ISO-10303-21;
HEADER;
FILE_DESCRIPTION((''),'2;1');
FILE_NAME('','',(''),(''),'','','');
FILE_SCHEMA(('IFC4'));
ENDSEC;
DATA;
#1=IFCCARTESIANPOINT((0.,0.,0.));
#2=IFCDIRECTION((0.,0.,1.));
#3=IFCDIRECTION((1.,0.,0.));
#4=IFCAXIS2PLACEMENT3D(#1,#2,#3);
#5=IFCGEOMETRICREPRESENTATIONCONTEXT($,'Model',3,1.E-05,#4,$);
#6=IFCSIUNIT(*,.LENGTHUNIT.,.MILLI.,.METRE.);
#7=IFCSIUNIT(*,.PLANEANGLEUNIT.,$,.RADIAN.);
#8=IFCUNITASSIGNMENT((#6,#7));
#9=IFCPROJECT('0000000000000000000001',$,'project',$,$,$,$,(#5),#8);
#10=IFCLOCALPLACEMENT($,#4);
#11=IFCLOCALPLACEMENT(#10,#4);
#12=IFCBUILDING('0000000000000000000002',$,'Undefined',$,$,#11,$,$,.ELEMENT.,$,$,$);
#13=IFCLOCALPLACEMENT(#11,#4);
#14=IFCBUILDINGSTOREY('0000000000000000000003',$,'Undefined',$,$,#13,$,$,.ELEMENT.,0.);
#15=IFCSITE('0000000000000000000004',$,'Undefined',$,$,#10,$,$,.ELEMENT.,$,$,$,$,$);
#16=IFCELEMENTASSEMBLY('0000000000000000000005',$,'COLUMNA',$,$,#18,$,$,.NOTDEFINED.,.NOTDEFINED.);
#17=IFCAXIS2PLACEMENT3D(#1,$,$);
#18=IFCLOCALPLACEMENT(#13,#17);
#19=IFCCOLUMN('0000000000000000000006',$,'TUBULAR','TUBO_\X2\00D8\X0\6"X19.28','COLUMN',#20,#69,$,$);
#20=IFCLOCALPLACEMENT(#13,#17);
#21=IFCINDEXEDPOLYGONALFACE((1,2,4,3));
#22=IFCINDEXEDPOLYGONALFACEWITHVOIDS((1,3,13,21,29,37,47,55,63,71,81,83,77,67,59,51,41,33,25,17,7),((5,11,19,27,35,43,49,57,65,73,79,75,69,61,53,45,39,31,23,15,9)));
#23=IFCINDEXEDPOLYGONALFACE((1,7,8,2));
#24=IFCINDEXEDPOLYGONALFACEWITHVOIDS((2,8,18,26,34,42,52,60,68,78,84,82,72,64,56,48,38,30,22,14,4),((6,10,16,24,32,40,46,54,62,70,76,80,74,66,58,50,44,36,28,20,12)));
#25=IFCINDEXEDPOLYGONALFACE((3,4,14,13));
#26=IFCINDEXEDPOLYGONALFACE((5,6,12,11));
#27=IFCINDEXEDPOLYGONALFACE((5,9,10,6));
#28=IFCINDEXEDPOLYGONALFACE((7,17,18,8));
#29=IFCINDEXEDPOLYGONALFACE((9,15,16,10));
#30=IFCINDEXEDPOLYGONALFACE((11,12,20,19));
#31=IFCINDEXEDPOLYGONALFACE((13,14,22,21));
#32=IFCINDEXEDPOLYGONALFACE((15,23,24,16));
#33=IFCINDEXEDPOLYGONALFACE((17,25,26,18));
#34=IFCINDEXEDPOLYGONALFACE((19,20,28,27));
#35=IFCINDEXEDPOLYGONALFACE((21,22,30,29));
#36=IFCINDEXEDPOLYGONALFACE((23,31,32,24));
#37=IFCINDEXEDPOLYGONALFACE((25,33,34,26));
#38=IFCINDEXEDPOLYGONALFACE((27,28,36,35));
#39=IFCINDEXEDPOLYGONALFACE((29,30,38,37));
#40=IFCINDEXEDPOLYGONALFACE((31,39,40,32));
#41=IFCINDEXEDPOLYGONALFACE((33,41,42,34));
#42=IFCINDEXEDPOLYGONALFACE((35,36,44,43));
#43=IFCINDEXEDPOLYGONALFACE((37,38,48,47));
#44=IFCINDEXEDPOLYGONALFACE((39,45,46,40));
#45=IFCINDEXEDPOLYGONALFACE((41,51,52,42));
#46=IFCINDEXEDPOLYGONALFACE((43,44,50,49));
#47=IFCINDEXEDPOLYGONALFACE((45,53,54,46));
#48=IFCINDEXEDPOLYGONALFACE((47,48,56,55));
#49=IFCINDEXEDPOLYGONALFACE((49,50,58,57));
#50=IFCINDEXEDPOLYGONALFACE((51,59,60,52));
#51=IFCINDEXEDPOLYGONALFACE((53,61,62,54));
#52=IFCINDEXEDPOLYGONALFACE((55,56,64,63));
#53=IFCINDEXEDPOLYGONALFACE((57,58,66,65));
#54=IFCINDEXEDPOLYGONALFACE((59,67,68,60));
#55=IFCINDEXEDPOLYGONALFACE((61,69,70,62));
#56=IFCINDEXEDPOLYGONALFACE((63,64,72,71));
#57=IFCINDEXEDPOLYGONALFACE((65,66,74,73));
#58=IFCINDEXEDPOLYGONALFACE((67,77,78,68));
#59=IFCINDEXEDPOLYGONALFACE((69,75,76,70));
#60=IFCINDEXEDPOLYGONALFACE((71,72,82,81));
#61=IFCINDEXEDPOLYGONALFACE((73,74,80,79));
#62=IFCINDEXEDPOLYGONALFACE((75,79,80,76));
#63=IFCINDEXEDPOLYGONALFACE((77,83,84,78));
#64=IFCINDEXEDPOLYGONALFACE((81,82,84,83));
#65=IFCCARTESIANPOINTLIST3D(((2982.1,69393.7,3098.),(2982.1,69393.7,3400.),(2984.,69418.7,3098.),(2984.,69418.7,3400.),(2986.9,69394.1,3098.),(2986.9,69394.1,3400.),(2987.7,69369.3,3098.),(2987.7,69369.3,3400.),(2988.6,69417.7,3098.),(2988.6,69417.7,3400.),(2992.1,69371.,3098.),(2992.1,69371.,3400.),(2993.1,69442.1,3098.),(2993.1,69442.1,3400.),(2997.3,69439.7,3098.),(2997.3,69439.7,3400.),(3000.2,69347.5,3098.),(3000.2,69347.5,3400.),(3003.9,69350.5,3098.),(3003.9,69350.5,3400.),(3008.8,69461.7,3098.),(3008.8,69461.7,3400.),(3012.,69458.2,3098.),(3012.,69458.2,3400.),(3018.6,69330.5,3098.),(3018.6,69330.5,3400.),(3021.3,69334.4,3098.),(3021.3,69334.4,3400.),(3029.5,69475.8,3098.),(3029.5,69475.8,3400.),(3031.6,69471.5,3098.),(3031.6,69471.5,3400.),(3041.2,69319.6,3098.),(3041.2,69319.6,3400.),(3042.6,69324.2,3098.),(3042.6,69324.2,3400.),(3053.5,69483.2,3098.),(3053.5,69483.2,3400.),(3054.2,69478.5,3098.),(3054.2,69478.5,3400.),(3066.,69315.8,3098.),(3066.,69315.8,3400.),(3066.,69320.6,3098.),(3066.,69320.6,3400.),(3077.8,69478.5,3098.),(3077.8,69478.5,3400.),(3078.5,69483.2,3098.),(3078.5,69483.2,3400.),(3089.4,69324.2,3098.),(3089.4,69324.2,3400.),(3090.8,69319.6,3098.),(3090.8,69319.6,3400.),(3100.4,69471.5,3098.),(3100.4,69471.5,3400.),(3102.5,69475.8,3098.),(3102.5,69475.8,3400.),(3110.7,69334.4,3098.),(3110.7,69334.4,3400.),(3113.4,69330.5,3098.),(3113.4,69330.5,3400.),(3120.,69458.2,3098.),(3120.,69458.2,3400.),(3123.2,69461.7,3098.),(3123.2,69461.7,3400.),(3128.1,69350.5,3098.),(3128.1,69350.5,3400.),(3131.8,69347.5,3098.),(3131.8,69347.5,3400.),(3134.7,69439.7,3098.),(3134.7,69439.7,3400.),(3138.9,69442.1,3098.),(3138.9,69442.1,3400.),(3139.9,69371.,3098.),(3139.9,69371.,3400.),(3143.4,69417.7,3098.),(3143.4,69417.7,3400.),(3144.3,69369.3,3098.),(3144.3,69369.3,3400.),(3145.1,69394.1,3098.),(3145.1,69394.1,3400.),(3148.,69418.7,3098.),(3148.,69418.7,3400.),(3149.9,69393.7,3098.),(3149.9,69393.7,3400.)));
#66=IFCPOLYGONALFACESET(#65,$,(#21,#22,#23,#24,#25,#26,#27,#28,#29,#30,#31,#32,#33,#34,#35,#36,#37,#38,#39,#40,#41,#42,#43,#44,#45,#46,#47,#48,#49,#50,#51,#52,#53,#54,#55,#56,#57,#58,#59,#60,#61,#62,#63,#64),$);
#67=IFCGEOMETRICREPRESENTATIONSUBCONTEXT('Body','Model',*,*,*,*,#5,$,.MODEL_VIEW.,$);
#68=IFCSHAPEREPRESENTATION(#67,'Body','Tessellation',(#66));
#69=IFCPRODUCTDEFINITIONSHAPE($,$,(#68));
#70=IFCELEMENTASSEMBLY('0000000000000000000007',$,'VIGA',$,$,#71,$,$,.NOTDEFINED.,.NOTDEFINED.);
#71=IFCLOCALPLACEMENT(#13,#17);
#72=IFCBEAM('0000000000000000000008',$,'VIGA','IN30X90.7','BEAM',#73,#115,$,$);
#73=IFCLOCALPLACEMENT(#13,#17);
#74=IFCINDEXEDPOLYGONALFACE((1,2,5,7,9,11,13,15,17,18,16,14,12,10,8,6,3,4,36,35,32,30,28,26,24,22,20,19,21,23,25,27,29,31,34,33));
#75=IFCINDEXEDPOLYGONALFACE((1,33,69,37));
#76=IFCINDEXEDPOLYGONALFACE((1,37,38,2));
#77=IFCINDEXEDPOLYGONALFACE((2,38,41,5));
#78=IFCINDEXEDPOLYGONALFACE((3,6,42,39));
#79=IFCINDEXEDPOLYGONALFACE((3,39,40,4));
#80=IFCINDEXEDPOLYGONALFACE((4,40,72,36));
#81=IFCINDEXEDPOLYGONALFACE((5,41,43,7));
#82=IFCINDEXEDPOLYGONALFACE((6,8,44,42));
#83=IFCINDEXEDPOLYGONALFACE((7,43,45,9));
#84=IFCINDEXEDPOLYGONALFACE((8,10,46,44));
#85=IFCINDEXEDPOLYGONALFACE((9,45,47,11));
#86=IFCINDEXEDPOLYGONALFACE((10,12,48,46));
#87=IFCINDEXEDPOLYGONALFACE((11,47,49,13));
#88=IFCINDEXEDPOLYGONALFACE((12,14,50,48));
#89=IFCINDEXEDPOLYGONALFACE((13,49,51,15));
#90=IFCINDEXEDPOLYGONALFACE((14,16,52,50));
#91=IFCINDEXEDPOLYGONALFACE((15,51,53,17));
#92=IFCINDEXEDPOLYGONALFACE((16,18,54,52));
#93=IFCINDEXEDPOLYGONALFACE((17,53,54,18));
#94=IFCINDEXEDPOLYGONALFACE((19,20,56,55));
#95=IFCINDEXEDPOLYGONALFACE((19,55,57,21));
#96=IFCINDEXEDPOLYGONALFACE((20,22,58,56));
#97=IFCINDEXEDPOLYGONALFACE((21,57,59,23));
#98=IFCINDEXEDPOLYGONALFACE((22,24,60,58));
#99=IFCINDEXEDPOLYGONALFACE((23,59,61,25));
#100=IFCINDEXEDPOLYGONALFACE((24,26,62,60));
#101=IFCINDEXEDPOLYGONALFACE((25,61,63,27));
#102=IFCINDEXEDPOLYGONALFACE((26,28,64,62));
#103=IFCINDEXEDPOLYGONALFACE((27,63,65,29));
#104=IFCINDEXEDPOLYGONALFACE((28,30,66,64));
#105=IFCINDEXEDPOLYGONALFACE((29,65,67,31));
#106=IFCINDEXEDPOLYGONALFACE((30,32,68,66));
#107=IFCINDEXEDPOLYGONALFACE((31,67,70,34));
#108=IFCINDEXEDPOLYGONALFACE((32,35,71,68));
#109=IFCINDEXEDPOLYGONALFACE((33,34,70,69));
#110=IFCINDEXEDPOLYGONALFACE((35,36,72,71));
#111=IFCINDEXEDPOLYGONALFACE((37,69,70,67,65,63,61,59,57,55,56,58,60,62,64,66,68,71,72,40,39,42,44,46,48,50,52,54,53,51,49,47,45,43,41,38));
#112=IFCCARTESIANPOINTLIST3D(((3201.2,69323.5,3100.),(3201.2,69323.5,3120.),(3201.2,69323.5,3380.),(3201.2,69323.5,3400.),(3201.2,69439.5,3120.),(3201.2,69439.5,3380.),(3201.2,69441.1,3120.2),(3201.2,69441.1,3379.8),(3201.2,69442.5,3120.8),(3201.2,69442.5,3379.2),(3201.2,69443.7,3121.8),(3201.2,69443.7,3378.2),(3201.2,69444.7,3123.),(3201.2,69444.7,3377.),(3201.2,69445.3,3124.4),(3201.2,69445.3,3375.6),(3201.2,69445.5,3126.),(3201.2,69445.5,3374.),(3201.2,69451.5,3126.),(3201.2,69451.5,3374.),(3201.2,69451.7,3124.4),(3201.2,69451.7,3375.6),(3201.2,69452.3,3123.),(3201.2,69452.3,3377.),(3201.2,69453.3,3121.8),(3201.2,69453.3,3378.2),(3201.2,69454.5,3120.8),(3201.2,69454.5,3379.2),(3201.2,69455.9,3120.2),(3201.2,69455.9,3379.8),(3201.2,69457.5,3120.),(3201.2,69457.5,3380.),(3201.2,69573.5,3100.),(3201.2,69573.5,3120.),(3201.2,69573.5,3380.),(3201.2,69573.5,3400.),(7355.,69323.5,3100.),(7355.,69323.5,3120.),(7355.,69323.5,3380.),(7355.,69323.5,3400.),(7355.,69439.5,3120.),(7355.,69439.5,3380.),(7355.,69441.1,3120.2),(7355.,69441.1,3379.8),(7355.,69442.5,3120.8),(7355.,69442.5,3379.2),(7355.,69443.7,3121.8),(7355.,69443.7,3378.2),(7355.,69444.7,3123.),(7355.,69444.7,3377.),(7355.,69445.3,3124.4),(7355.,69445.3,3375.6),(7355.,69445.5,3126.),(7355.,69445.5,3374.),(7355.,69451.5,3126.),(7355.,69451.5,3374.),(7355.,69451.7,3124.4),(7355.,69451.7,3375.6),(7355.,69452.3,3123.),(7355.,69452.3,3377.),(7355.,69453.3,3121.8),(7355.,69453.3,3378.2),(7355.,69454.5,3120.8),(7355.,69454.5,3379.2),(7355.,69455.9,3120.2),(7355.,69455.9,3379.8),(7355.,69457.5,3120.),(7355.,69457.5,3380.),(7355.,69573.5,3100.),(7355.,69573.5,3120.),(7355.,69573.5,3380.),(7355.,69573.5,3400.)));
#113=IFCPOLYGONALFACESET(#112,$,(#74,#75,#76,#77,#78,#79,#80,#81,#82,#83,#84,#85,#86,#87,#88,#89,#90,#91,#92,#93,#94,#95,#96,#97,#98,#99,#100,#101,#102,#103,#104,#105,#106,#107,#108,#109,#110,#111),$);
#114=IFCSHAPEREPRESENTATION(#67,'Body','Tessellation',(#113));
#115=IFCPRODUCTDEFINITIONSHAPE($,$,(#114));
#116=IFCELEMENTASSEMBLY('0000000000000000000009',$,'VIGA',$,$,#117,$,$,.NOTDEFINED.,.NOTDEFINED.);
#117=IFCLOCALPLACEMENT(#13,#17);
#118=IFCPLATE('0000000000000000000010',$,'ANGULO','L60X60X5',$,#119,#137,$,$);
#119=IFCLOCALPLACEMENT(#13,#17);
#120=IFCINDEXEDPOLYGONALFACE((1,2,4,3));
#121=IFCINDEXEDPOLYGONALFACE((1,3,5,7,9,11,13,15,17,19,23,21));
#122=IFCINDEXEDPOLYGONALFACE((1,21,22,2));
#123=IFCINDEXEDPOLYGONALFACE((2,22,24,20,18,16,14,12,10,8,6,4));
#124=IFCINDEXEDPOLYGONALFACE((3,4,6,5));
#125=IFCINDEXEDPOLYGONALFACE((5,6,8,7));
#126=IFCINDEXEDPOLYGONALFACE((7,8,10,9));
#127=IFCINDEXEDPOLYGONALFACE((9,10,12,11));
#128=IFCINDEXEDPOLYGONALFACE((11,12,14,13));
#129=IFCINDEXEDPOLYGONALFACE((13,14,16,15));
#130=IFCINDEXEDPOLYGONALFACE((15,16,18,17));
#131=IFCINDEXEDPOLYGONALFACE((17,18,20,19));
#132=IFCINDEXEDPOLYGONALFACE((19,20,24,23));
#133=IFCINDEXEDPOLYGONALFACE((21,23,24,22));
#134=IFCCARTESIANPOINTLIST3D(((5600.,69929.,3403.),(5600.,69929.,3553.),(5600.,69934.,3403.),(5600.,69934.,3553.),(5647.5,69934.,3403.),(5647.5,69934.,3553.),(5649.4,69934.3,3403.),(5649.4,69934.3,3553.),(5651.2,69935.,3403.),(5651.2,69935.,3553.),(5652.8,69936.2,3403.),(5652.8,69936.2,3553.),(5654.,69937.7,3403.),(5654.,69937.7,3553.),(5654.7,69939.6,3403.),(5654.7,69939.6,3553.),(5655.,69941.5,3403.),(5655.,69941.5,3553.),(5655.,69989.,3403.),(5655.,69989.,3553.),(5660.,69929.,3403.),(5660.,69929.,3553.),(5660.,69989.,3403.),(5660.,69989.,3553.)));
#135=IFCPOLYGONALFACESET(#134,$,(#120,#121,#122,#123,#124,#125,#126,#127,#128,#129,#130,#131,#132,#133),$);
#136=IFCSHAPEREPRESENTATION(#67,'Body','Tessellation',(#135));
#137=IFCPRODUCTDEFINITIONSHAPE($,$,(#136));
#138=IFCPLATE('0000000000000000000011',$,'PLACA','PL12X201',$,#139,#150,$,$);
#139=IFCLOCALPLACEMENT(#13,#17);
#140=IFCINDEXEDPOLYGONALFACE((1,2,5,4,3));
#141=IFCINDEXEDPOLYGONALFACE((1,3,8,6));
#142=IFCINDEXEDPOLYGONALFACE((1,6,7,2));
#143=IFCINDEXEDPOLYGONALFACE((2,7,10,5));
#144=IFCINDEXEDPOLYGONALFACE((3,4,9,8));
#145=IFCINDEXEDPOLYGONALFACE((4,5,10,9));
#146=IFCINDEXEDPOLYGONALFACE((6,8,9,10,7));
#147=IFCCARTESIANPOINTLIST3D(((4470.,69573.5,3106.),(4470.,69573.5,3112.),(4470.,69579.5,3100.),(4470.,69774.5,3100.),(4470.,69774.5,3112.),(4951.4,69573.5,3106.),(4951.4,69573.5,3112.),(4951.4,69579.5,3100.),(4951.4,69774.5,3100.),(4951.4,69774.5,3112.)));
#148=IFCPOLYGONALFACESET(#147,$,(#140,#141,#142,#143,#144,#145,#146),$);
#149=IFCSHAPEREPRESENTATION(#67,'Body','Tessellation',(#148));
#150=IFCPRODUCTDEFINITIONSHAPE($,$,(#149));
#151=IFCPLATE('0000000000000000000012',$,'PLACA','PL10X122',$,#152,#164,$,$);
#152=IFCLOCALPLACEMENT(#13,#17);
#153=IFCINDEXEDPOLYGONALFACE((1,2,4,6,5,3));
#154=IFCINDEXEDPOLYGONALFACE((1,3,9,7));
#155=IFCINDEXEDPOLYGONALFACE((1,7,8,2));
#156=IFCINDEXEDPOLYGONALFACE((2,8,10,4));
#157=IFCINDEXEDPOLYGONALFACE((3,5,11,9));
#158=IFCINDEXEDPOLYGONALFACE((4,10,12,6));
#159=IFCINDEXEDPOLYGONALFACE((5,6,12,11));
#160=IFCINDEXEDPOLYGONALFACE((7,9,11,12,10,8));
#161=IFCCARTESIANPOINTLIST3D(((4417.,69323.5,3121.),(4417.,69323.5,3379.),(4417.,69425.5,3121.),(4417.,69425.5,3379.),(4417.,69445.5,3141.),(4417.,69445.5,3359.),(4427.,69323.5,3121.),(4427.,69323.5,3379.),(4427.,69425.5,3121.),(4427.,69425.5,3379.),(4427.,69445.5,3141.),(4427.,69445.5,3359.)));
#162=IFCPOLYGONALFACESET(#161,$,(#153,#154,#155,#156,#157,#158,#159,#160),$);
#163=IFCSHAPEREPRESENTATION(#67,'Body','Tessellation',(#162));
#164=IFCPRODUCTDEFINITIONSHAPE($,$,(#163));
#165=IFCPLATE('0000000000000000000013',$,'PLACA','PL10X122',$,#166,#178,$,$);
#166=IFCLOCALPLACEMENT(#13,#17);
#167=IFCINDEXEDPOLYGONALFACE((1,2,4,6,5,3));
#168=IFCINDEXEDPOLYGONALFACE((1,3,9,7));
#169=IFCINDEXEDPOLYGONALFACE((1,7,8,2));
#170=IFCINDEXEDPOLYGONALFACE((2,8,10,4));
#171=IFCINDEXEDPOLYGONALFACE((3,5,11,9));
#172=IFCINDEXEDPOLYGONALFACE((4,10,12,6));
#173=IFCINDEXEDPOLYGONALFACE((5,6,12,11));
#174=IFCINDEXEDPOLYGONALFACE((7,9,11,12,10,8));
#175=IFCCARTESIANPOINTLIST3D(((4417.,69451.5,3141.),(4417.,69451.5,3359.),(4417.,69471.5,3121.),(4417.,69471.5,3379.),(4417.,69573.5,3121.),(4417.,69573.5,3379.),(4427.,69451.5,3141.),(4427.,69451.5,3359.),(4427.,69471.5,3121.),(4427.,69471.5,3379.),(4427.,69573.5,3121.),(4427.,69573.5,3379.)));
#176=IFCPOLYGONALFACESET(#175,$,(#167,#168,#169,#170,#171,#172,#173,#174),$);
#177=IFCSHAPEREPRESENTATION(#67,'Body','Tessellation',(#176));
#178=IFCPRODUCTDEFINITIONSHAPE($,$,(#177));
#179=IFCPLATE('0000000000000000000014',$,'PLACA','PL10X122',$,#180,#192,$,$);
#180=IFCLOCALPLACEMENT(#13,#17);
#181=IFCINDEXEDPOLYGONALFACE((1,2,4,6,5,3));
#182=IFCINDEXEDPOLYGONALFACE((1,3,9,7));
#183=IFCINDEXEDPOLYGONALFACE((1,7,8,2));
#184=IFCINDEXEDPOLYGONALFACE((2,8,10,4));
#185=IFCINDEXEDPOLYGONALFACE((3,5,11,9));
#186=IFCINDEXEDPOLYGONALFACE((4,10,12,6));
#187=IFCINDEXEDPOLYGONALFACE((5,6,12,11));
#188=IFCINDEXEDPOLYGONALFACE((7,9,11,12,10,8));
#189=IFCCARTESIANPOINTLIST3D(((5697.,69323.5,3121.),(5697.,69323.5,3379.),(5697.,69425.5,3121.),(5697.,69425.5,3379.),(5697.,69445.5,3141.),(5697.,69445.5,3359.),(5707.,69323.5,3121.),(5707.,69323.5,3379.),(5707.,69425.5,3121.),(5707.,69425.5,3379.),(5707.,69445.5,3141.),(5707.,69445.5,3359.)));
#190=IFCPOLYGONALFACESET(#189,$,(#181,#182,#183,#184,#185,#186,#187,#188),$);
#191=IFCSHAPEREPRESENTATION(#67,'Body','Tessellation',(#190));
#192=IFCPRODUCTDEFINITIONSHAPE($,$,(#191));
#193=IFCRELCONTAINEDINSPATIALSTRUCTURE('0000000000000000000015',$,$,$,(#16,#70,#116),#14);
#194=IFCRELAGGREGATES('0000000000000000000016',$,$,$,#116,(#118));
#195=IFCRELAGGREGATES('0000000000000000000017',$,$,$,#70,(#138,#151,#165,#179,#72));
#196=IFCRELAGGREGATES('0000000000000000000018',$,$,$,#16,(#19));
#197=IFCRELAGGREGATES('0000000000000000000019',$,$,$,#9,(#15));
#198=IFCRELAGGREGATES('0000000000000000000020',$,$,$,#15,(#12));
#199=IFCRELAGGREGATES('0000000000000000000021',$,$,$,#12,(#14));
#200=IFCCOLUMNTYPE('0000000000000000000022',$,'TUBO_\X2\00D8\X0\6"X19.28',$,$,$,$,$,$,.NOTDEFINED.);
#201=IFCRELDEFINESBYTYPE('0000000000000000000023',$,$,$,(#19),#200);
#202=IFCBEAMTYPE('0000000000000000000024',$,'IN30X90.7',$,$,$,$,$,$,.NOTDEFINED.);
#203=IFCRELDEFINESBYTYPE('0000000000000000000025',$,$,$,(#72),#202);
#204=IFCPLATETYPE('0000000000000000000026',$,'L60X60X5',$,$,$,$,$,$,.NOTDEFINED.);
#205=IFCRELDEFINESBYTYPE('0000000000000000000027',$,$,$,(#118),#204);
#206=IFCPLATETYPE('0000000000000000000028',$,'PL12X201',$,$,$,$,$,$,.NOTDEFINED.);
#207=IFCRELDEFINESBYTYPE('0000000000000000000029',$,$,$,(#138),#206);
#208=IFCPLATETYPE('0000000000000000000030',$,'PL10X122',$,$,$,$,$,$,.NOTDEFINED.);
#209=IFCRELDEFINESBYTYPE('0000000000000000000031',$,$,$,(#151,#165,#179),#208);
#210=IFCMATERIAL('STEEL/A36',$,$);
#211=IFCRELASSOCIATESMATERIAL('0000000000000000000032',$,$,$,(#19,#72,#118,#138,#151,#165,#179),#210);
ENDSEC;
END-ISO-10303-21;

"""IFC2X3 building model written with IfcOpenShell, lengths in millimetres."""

from ifc_helpers import new_model, si_unit, frame, origin_with_axes, origin_2d_with_axis, place, context, subcontext, project, spatial, polyline, hollow_circle, i_section, l_section, outline, extrude, boolean, material, type_object, element, aggregate, save


model = new_model("IFC2X3")

# Units and contexts
model_context = context("Model", 3, precision=1e-05, world=origin_with_axes())
body_context = subcontext(model_context, "Body", "Model", "MODEL_VIEW")
ifc_project = project(units=[si_unit("LENGTHUNIT", "METRE", prefix="MILLI"), si_unit("PLANEANGLEUNIT", "RADIAN")], contexts=[model_context])

# Site, building, storey
site_placement = place(None, origin_with_axes())
site = spatial("IfcSite", under=ifc_project, at=site_placement, Name="Undefined", CompositionType="ELEMENT")
building_placement = place(site_placement, origin_with_axes())
building = spatial("IfcBuilding", under=site, at=building_placement, Name="Undefined", CompositionType="ELEMENT")
storey_placement = place(building_placement, origin_with_axes())
storey = spatial("IfcBuildingStorey", under=building, at=storey_placement, Name="Undefined", CompositionType="ELEMENT", Elevation=0.0)

# Element assembly, column
assembly_1_placement = place(storey_placement, origin_with_axes())
assembly_1 = element("IfcElementAssembly", 1, at=assembly_1_placement, inside=storey, Name="COLUMNA", AssemblyPlace="NOTDEFINED", PredefinedType="NOTDEFINED")
ifc_material_1 = material(Name="STEEL/A36")
column_type = type_object("IfcColumnType", Name="TUBO_Ø6\"X19.28", PredefinedType="NOTDEFINED")
column_placement = place(assembly_1_placement, frame((3066.0, 69400.0, 3098.0), z_axis=(0.0, 0.0, 1.0), x_axis=(-1.0, 0.0, 0.0)))
column = element("IfcColumn", 2, at=column_placement, type_object=column_type, material=ifc_material_1, Name="TUBULAR", Description="TUBO_Ø6\"X19.28", ObjectType="COLUMN", context=body_context, shape_type="SweptSolid", body=[
    extrude(hollow_circle(Radius=84.2, WallThickness=4.8, at=origin_2d_with_axis()), frame((0.0, 0.0, 302.0), z_axis=(0.0, 0.0, -1.0), x_axis=(0.0, 1.0, 0.0)), (0.0, 0.0, 1.0), 302.0),
])

# Element assembly, beam
assembly_2_placement = place(storey_placement, origin_with_axes())
assembly_2 = element("IfcElementAssembly", 3, at=assembly_2_placement, inside=storey, Name="VIGA", AssemblyPlace="NOTDEFINED", PredefinedType="NOTDEFINED")
beam_type = type_object("IfcBeamType", Name="IN30X90.7", PredefinedType="NOTDEFINED")
beam_placement = place(assembly_2_placement, frame((3201.2, 69448.5, 3250.0), z_axis=(0.0, 0.0, 1.0), x_axis=(1.0, 0.0, 0.0)))
beam = element("IfcBeam", 4, at=beam_placement, type_object=beam_type, material=ifc_material_1, Name="VIGA", Description="IN30X90.7", ObjectType="BEAM", context=body_context, shape_type="SweptSolid", body=[
    extrude(i_section(OverallWidth=250.0, OverallDepth=300.0, WebThickness=6.0, FlangeThickness=20.0, FilletRadius=6.0, at=origin_2d_with_axis()), frame((4153.8, 0.0, 0.0), z_axis=(-1.0, 0.0, 0.0), x_axis=(0.0, -1.0, 0.0)), (0.0, 0.0, 1.0), 4153.8),
])

# Element assembly, plate
assembly_3_placement = place(storey_placement, origin_with_axes())
assembly_3 = element("IfcElementAssembly", 5, at=assembly_3_placement, inside=storey, Name="VIGA", AssemblyPlace="NOTDEFINED", PredefinedType="NOTDEFINED")
plate_type_1 = type_object("IfcPlateType", Name="L60X60X5", PredefinedType="NOTDEFINED")
plate_1_placement = place(assembly_3_placement, frame((5630.0, 69959.0, 3403.0), z_axis=(0.0, 1.0, 0.0), x_axis=(0.0, 0.0, 1.0)))
plate_1 = element("IfcPlate", 6, at=plate_1_placement, type_object=plate_type_1, material=ifc_material_1, Name="ANGULO", Description="L60X60X5", context=body_context, shape_type="SweptSolid", body=[
    extrude(l_section(Depth=60.0, Width=60.0, Thickness=5.0, FilletRadius=7.5, at=origin_2d_with_axis()), frame((150.0, 0.0, 0.0), z_axis=(-1.0, 0.0, 0.0), x_axis=(0.0, -1.0, 0.0)), (0.0, 0.0, 1.0), 150.0),
])
aggregate(assembly_3, [plate_1])

# Plates
plate_type_2 = type_object("IfcPlateType", Name="PL12X201", PredefinedType="NOTDEFINED")
plate_2_placement = place(assembly_2_placement, frame((4951.4, 69573.5, 3106.0), z_axis=(0.0, 0.0, -1.0), x_axis=(-1.0, 0.0, 0.0)))
plate_2 = element("IfcPlate", 7, at=plate_2_placement, type_object=plate_type_2, material=ifc_material_1, Name="PLACA", Description="PL12X201", context=body_context, shape_type="CSG", body=[
    boolean("DIFFERENCE", extrude(outline(polyline([(0.0, 0.0), (481.4, 0.0), (481.4, 201.0), (0.0, 201.0), (0.0, 0.0)])), frame((0.0, 0.0, -6.0), z_axis=(0.0, 0.0, 1.0), x_axis=(1.0, 0.0, 0.0)), (0.0, 0.0, 1.0), 12.0), extrude(outline(polyline([(0.0, 0.0), (6.0, 0.0), (6.0, 6.0), (0.0, 0.0)])), frame((-9.3, 6.0, 6.0), z_axis=(1.0, 0.0, 0.0), x_axis=(0.0, -1.0, 0.0)), (0.0, 0.0, 1.0), 500.0)),
])
plate_type_3 = type_object("IfcPlateType", Name="PL10X122", PredefinedType="NOTDEFINED")
plate_3_placement = place(assembly_2_placement, frame((4422.0, 69323.5, 3121.0), z_axis=(1.0, 0.0, 0.0), x_axis=(0.0, 1.0, 0.0)))
plate_3 = element("IfcPlate", 8, at=plate_3_placement, type_object=plate_type_3, material=ifc_material_1, Name="PLACA", Description="PL10X122", context=body_context, shape_type="SweptSolid", body=[
    extrude(outline(polyline([(0.0, 0.0), (102.0, 0.0), (122.0, 20.0), (122.0, 238.0), (102.0, 258.0), (0.0, 258.0), (0.0, 0.0)])), frame((0.0, 0.0, -5.0), z_axis=(0.0, 0.0, 1.0), x_axis=(1.0, 0.0, 0.0)), (0.0, 0.0, 1.0), 10.0),
])
plate_4_placement = place(assembly_2_placement, frame((4422.0, 69451.5, 3121.0), z_axis=(1.0, 0.0, 0.0), x_axis=(0.0, 1.0, 0.0)))
plate_4 = element("IfcPlate", 9, at=plate_4_placement, type_object=plate_type_3, material=ifc_material_1, Name="PLACA", Description="PL10X122", context=body_context, shape_type="SweptSolid", body=[
    extrude(outline(polyline([(0.0, 20.0), (20.0, 0.0), (122.0, 0.0), (122.0, 258.0), (20.0, 258.0), (0.0, 238.0), (0.0, 20.0)])), frame((0.0, 0.0, -5.0), z_axis=(0.0, 0.0, 1.0), x_axis=(1.0, 0.0, 0.0)), (0.0, 0.0, 1.0), 10.0),
])
plate_5_placement = place(assembly_2_placement, frame((5702.0, 69445.5, 3121.0), z_axis=(-1.0, 0.0, 0.0), x_axis=(0.0, -1.0, 0.0)))
plate_5 = element("IfcPlate", 10, at=plate_5_placement, type_object=plate_type_3, material=ifc_material_1, Name="PLACA", Description="PL10X122", context=body_context, shape_type="SweptSolid", body=[
    extrude(outline(polyline([(0.0, 20.0), (20.0, 0.0), (122.0, 0.0), (122.0, 258.0), (20.0, 258.0), (0.0, 238.0), (0.0, 20.0)])), frame((0.0, 0.0, -5.0), z_axis=(0.0, 0.0, 1.0), x_axis=(1.0, 0.0, 0.0)), (0.0, 0.0, 1.0), 10.0),
])

aggregate(assembly_2, [plate_2, plate_3, plate_4, plate_5, beam])
aggregate(assembly_1, [column])

save(model, "model.ifc")
